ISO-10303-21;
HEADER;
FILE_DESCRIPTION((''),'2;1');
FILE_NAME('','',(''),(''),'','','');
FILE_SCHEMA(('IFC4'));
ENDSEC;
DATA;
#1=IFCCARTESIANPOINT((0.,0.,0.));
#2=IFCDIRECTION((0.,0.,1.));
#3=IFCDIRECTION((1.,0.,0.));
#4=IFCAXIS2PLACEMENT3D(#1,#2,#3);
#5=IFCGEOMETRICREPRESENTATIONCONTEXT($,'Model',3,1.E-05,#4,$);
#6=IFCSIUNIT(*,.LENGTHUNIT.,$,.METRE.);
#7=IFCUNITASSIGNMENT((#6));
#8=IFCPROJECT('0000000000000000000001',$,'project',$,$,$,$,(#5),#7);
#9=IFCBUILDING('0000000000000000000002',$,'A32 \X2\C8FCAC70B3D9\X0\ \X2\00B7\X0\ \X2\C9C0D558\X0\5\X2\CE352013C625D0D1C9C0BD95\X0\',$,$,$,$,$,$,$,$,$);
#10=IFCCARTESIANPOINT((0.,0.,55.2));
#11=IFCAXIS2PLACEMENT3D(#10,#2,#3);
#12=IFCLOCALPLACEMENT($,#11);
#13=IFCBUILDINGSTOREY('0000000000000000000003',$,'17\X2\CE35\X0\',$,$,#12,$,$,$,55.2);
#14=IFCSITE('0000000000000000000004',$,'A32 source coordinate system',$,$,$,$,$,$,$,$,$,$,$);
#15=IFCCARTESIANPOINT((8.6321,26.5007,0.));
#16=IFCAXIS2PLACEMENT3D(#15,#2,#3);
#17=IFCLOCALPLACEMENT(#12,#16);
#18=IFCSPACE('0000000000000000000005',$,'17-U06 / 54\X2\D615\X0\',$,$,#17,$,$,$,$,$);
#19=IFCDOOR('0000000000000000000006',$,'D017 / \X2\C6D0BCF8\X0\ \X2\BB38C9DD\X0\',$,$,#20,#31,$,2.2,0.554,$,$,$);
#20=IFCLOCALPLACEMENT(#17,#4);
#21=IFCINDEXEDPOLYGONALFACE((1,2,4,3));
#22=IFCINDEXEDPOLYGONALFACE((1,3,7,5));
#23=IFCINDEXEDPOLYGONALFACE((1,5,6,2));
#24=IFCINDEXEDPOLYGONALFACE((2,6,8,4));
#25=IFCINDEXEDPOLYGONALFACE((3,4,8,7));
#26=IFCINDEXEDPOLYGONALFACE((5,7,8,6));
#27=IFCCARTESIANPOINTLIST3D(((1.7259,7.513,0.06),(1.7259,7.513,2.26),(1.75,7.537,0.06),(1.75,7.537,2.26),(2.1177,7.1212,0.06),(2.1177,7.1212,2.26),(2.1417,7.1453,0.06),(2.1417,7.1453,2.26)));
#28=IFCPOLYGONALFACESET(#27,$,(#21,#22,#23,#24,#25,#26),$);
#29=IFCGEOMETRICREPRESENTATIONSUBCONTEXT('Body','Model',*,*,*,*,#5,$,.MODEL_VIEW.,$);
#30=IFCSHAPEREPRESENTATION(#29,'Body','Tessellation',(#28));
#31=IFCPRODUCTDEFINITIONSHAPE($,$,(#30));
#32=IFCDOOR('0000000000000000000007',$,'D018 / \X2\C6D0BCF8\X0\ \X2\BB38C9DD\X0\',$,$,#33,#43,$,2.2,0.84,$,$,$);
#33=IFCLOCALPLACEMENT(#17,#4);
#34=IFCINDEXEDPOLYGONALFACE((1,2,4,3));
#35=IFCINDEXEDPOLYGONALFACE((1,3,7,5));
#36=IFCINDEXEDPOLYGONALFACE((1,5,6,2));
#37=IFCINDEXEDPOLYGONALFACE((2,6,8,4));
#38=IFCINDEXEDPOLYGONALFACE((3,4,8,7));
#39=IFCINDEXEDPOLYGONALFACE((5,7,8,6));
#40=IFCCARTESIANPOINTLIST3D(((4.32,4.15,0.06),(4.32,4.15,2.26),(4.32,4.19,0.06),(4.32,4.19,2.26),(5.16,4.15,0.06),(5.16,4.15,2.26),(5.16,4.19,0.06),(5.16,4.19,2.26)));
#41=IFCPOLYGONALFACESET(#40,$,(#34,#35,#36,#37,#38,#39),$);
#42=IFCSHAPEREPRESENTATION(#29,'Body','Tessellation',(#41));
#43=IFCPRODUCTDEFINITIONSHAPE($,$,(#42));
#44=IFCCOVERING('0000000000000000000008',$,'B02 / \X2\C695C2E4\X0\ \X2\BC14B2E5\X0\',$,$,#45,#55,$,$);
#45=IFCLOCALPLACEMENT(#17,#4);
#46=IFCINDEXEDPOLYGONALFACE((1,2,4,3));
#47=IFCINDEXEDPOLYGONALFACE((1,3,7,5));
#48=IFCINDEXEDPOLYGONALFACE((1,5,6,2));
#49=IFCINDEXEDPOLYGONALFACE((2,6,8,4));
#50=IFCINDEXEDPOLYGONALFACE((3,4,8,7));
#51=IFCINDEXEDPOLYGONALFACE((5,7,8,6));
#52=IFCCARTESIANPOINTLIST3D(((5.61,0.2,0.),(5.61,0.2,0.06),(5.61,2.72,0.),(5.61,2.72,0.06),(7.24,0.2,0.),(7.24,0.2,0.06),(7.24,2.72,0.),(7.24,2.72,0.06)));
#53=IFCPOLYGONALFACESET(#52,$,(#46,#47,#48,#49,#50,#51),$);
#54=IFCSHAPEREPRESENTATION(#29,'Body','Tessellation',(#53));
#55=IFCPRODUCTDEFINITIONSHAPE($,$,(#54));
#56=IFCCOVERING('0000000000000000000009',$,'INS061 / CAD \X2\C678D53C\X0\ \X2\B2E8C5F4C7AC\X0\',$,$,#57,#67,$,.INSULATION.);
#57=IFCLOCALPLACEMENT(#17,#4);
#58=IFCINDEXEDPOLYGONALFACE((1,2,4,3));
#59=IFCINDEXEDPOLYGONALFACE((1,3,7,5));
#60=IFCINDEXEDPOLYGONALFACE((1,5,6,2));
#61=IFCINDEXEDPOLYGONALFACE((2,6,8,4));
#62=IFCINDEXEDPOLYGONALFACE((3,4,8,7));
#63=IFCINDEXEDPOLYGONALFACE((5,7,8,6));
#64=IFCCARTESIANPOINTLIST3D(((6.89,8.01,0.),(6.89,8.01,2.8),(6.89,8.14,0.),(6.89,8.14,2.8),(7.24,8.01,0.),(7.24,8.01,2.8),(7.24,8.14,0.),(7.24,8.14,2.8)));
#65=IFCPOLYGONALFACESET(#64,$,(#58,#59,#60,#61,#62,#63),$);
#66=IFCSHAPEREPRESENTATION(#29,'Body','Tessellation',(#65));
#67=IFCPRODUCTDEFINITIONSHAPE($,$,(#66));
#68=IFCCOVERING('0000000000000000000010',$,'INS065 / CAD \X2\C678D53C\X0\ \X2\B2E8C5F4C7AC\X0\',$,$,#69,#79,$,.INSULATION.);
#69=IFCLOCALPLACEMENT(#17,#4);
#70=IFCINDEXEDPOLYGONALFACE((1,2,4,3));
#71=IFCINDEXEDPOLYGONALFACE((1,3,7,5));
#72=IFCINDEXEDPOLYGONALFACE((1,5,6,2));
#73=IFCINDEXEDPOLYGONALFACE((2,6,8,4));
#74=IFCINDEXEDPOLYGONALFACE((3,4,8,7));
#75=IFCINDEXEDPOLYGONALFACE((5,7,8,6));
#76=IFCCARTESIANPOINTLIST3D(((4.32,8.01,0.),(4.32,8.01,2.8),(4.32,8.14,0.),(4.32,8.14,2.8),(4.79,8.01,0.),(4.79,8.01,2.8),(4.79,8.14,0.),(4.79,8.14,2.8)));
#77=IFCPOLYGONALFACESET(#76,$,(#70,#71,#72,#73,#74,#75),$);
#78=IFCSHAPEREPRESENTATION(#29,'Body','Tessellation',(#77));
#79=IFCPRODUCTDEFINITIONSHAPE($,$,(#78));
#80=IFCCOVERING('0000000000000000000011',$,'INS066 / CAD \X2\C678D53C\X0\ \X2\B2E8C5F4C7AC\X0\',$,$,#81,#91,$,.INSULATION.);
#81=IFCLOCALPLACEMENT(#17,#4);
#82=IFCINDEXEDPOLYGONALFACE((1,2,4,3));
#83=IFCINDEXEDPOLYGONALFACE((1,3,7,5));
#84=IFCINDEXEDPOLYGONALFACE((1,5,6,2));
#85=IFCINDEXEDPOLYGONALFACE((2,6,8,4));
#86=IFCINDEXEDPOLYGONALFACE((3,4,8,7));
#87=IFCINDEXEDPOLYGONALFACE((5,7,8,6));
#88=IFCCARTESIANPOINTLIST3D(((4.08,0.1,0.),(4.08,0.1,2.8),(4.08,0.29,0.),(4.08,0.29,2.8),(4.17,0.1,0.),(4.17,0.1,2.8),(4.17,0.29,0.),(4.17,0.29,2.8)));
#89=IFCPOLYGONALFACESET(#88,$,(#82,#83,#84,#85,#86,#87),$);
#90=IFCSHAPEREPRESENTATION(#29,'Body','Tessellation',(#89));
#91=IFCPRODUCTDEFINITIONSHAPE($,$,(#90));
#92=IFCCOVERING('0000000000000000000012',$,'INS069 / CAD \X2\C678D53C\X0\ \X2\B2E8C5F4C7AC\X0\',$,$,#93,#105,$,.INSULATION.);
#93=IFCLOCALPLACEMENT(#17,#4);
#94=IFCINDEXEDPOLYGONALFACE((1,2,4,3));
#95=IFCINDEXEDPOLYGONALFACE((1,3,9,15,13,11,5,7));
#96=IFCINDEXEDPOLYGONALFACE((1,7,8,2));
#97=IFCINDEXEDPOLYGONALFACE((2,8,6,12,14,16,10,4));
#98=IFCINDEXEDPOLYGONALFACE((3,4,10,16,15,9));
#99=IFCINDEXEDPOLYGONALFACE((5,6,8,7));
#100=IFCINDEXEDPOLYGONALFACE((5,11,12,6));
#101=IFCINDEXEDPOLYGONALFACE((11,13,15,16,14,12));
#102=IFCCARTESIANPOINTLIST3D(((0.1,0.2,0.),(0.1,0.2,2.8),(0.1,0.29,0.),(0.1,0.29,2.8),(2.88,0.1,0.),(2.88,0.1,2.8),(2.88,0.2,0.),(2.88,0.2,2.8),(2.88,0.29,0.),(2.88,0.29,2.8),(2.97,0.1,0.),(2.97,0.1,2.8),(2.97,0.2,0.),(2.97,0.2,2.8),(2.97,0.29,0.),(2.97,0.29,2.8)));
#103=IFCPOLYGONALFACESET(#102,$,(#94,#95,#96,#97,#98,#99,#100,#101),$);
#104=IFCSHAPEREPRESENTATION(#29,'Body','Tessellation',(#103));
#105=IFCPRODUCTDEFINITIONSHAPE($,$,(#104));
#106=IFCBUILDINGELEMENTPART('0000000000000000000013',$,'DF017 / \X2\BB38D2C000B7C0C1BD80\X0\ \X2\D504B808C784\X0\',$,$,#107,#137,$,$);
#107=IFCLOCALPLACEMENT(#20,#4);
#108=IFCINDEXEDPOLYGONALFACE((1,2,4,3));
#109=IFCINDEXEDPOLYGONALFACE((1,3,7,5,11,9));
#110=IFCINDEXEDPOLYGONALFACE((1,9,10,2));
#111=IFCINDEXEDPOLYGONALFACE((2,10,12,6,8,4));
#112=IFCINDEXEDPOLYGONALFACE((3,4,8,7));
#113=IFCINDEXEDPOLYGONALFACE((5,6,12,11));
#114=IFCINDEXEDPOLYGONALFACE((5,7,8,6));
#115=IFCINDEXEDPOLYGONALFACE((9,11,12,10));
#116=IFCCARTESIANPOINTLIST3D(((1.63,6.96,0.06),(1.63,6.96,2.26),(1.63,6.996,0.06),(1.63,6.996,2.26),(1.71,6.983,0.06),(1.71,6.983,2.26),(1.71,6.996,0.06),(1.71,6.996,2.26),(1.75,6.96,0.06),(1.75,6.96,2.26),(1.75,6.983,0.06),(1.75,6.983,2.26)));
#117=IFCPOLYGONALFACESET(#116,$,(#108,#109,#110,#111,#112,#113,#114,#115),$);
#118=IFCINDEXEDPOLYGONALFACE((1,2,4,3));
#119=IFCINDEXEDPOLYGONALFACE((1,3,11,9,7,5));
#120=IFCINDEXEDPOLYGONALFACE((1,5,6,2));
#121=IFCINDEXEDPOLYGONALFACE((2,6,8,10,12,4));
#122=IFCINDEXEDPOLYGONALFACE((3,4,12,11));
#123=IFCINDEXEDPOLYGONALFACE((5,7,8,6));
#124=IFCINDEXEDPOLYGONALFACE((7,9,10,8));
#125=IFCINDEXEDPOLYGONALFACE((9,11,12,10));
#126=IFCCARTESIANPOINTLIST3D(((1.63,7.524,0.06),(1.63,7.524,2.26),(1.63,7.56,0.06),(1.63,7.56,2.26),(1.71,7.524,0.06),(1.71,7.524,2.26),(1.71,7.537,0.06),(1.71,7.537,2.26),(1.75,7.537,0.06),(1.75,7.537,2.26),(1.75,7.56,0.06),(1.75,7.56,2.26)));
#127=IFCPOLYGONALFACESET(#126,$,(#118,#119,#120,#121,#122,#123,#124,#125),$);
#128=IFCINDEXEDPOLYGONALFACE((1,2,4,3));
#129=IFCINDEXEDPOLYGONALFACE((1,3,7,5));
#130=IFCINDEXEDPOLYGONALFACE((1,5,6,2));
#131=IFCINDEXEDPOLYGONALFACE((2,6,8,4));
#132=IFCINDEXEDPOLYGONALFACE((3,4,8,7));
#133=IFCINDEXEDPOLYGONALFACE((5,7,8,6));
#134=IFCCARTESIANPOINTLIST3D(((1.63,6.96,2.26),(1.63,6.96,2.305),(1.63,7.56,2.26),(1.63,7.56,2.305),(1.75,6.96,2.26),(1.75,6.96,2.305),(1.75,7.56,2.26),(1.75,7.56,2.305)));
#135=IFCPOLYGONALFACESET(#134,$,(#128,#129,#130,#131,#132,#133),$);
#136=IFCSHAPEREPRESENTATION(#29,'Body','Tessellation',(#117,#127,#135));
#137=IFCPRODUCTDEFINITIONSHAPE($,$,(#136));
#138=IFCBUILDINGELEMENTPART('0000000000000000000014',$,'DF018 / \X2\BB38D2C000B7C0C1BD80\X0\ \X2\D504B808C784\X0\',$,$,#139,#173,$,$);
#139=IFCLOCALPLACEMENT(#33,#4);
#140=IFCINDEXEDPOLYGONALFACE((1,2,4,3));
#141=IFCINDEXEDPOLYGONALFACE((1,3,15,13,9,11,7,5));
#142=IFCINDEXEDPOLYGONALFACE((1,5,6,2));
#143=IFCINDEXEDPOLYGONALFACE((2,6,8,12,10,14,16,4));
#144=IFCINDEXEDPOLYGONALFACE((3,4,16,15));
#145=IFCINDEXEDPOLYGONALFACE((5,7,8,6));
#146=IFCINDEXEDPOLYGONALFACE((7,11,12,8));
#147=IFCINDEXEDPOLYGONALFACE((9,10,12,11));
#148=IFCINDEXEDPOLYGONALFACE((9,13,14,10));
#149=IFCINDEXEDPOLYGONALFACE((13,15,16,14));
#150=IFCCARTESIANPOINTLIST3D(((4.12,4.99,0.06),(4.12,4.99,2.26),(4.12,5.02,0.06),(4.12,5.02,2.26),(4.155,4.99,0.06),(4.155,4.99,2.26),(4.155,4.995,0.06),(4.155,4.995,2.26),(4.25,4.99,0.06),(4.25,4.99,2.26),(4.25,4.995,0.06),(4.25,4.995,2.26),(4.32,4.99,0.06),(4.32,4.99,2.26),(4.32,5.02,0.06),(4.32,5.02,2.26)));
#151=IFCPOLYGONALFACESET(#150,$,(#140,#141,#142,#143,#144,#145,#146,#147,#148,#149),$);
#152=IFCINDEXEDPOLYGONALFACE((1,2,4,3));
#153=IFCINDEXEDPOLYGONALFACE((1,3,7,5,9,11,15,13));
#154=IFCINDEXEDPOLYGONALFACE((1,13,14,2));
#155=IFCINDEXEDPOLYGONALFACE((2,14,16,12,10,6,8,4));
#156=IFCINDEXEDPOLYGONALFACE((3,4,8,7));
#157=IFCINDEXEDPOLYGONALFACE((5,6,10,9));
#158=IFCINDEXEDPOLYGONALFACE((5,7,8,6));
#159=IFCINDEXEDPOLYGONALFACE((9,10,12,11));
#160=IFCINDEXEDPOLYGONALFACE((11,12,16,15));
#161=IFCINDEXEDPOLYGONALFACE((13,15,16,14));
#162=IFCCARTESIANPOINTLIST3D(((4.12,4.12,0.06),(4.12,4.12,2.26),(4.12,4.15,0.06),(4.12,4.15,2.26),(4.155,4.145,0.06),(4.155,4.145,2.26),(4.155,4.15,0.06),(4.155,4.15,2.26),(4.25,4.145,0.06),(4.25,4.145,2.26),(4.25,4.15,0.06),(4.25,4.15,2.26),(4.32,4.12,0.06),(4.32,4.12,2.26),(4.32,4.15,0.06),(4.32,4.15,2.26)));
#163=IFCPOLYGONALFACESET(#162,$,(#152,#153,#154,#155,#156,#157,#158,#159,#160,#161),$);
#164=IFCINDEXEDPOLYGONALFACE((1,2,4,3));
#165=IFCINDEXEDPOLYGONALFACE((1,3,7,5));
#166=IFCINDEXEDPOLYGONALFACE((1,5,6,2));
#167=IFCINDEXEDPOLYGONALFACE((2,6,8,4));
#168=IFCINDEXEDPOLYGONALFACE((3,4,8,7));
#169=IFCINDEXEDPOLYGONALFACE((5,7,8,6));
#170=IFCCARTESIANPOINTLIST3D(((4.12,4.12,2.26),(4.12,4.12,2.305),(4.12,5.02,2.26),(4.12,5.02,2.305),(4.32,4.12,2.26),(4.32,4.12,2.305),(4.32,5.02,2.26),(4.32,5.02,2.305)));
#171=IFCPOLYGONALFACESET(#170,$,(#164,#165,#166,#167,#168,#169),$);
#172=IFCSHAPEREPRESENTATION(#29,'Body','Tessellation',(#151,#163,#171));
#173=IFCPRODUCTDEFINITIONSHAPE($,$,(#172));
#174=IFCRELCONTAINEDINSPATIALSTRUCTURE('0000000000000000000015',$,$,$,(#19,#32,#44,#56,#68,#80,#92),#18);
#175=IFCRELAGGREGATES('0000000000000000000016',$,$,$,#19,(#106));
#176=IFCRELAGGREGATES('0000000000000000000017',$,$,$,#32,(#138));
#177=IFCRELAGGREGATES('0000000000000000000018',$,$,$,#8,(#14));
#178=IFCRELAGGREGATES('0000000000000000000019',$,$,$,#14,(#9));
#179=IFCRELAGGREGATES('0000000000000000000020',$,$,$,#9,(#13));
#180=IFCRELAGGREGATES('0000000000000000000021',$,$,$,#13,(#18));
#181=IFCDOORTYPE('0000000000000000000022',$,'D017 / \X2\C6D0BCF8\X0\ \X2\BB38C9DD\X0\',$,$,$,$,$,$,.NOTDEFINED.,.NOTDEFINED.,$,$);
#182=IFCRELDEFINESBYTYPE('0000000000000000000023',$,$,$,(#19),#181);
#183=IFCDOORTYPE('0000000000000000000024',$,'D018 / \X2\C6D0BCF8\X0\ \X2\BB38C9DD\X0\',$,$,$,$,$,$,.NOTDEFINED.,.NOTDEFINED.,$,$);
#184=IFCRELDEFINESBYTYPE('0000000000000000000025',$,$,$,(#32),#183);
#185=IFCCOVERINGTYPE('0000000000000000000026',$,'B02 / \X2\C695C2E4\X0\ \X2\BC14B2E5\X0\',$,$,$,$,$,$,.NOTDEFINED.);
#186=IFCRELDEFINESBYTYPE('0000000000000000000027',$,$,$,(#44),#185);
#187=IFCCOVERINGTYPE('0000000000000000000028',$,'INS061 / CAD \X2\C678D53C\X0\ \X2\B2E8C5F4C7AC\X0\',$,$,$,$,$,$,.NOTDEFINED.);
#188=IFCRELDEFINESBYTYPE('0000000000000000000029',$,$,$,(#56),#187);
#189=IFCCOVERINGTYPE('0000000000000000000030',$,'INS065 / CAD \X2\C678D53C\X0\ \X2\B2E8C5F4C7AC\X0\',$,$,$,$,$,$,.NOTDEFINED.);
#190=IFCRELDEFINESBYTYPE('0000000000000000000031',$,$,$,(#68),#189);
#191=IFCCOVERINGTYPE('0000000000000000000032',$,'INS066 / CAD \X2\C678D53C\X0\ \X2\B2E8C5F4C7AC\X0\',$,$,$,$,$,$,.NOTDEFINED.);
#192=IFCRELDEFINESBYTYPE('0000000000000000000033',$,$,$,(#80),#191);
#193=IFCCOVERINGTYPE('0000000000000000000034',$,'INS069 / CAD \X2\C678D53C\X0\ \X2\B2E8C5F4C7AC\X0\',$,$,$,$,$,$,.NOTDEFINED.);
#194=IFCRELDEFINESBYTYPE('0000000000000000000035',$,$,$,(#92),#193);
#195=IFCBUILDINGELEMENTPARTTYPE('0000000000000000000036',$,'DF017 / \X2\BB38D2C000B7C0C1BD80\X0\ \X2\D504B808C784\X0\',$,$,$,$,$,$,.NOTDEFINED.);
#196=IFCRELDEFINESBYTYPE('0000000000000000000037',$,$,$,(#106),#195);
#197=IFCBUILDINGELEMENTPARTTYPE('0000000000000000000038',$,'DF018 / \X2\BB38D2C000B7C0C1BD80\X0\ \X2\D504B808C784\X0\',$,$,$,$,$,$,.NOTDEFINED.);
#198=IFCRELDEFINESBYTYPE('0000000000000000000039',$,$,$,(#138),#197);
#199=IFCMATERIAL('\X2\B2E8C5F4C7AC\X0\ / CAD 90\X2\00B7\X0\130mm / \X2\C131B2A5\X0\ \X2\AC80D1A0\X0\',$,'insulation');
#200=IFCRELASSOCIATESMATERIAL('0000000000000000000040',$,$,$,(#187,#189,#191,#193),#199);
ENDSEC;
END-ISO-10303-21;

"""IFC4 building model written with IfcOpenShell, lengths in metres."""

from ifc_helpers import new_model, si_unit, frame, origin, origin_with_axes, place, context, subcontext, project, spatial, polyline, outline, extrude, source, transform, mapped, material, type_object, type_shapes, element, aggregate, save


model = new_model("IFC4")

# Units and contexts
model_context = context("Model", 3, precision=1e-05, world=origin_with_axes())
body_context = subcontext(model_context, "Body", "Model", "MODEL_VIEW")
ifc_project = project(units=[si_unit("LENGTHUNIT", "METRE")], contexts=[model_context])

# Site, building, storey, space
storey_placement = place(None, frame((0.0, 0.0, 55.2), z_axis=(0.0, 0.0, 1.0), x_axis=(1.0, 0.0, 0.0)))
space_1_placement = place(storey_placement, frame((8.6321, 26.5007, 0.0), z_axis=(0.0, 0.0, 1.0), x_axis=(1.0, 0.0, 0.0)))
site = spatial("IfcSite", under=ifc_project, Name="A32 source coordinate system")
building = spatial("IfcBuilding", under=site, Name="A32 주거동 · 지하5층–옥탑지붕")
storey = spatial("IfcBuildingStorey", under=building, at=storey_placement, Name="17층", Elevation=55.2)
space_1 = spatial("IfcSpace", under=storey, at=space_1_placement, Name="17-U06 / 54형")

# Doors
door_type_1 = type_object("IfcDoorType", Name="D017 / 원본 문짝", OperationType="NOTDEFINED", PredefinedType="NOTDEFINED")
shared_shape_1 = source(origin(), body_context, "Body", "SweptSolid", [
    extrude(outline(polyline([(1.75, 7.537), (2.1417, 7.1453), (2.1177, 7.1212), (1.7259, 7.513), (1.75, 7.537)])), frame((0.0, 0.0, 0.06)), (0.0, 0.0, 1.0), 2.2),
])
type_shapes(door_type_1, [shared_shape_1])
door_1_placement = place(space_1_placement, origin_with_axes())
door_1 = element("IfcDoor", 1, at=door_1_placement, inside=space_1, type_object=door_type_1, Name="D017 / 원본 문짝", OverallHeight=2.2, OverallWidth=0.554, context=body_context, shape_type="MappedRepresentation", body=[
    mapped(shared_shape_1, transform((0.0, 0.0, 0.0), scale=1.0)),
])
door_type_2 = type_object("IfcDoorType", Name="D018 / 원본 문짝", OperationType="NOTDEFINED", PredefinedType="NOTDEFINED")
shared_shape_2 = source(origin(), body_context, "Body", "SweptSolid", [
    extrude(outline(polyline([(5.16, 4.19), (5.16, 4.15), (4.32, 4.15), (4.32, 4.19), (5.16, 4.19)])), frame((0.0, 0.0, 0.06)), (0.0, 0.0, 1.0), 2.2),
])
type_shapes(door_type_2, [shared_shape_2])
door_2_placement = place(space_1_placement, origin_with_axes())
door_2 = element("IfcDoor", 2, at=door_2_placement, inside=space_1, type_object=door_type_2, Name="D018 / 원본 문짝", OverallHeight=2.2, OverallWidth=0.84, context=body_context, shape_type="MappedRepresentation", body=[
    mapped(shared_shape_2, transform((0.0, 0.0, 0.0), scale=1.0)),
])

# Coverings
covering_type_1 = type_object("IfcCoveringType", Name="B02 / 욕실 바닥", PredefinedType="NOTDEFINED")
shared_shape_3 = source(origin(), body_context, "Body", "SweptSolid", [
    extrude(outline(polyline([(5.61, 2.72), (7.24, 2.72), (7.24, 0.2), (5.61, 0.2), (5.61, 2.72)])), origin(), (0.0, 0.0, 1.0), 0.06),
])
type_shapes(covering_type_1, [shared_shape_3])
covering_1_placement = place(space_1_placement, origin_with_axes())
element("IfcCovering", 3, at=covering_1_placement, inside=space_1, type_object=covering_type_1, Name="B02 / 욕실 바닥", context=body_context, shape_type="MappedRepresentation", body=[
    mapped(shared_shape_3, transform((0.0, 0.0, 0.0), scale=1.0)),
])
ifc_material = material(Name="단열재 / CAD 90·130mm / 성능 검토", Category="insulation")
covering_type_2 = type_object("IfcCoveringType", Name="INS061 / CAD 외피 단열재", PredefinedType="NOTDEFINED", material=ifc_material)
shared_shape_4 = source(origin(), body_context, "Body", "SweptSolid", [
    extrude(outline(polyline([(6.89, 8.01), (6.89, 8.14), (7.24, 8.14), (7.24, 8.01), (6.89, 8.01)])), origin(), (0.0, 0.0, 1.0), 2.8),
])
type_shapes(covering_type_2, [shared_shape_4])
covering_2_placement = place(space_1_placement, origin_with_axes())
element("IfcCovering", 4, at=covering_2_placement, inside=space_1, type_object=covering_type_2, Name="INS061 / CAD 외피 단열재", PredefinedType="INSULATION", context=body_context, shape_type="MappedRepresentation", body=[
    mapped(shared_shape_4, transform((0.0, 0.0, 0.0), scale=1.0)),
])
covering_type_3 = type_object("IfcCoveringType", Name="INS065 / CAD 외피 단열재", PredefinedType="NOTDEFINED", material=ifc_material)
shared_shape_5 = source(origin(), body_context, "Body", "SweptSolid", [
    extrude(outline(polyline([(4.32, 8.01), (4.32, 8.14), (4.79, 8.14), (4.79, 8.01), (4.32, 8.01)])), origin(), (0.0, 0.0, 1.0), 2.8),
])
type_shapes(covering_type_3, [shared_shape_5])
covering_3_placement = place(space_1_placement, origin_with_axes())
element("IfcCovering", 5, at=covering_3_placement, inside=space_1, type_object=covering_type_3, Name="INS065 / CAD 외피 단열재", PredefinedType="INSULATION", context=body_context, shape_type="MappedRepresentation", body=[
    mapped(shared_shape_5, transform((0.0, 0.0, 0.0), scale=1.0)),
])
covering_type_4 = type_object("IfcCoveringType", Name="INS066 / CAD 외피 단열재", PredefinedType="NOTDEFINED", material=ifc_material)
shared_shape_6 = source(origin(), body_context, "Body", "SweptSolid", [
    extrude(outline(polyline([(4.08, 0.29), (4.17, 0.29), (4.17, 0.1), (4.08, 0.1), (4.08, 0.29)])), origin(), (0.0, 0.0, 1.0), 2.8),
])
type_shapes(covering_type_4, [shared_shape_6])
covering_4_placement = place(space_1_placement, origin_with_axes())
element("IfcCovering", 6, at=covering_4_placement, inside=space_1, type_object=covering_type_4, Name="INS066 / CAD 외피 단열재", PredefinedType="INSULATION", context=body_context, shape_type="MappedRepresentation", body=[
    mapped(shared_shape_6, transform((0.0, 0.0, 0.0), scale=1.0)),
])
covering_type_5 = type_object("IfcCoveringType", Name="INS069 / CAD 외피 단열재", PredefinedType="NOTDEFINED", material=ifc_material)
shared_shape_7 = source(origin(), body_context, "Body", "SweptSolid", [
    extrude(outline(polyline([(2.97, 0.1), (2.88, 0.1), (2.88, 0.2), (0.1, 0.2), (0.1, 0.29), (2.88, 0.29), (2.97, 0.29), (2.97, 0.2), (2.97, 0.1)])), origin(), (0.0, 0.0, 1.0), 2.8),
])
type_shapes(covering_type_5, [shared_shape_7])
covering_5_placement = place(space_1_placement, origin_with_axes())
element("IfcCovering", 7, at=covering_5_placement, inside=space_1, type_object=covering_type_5, Name="INS069 / CAD 외피 단열재", PredefinedType="INSULATION", context=body_context, shape_type="MappedRepresentation", body=[
    mapped(shared_shape_7, transform((0.0, 0.0, 0.0), scale=1.0)),
])

# Building element parts
building_element_part_type_1 = type_object("IfcBuildingElementPartType", Name="DF017 / 문틀·상부 프레임", PredefinedType="NOTDEFINED")
shared_shape_8 = source(origin(), body_context, "Body", "SweptSolid", [
    extrude(outline(polyline([(1.63, 6.996), (1.71, 6.996), (1.71, 6.983), (1.75, 6.983), (1.75, 6.96), (1.63, 6.96), (1.63, 6.996)])), frame((0.0, 0.0, 0.06)), (0.0, 0.0, 1.0), 2.2),
    extrude(outline(polyline([(1.75, 7.56), (1.75, 7.537), (1.71, 7.537), (1.71, 7.524), (1.63, 7.524), (1.63, 7.56), (1.75, 7.56)])), frame((0.0, 0.0, 0.06)), (0.0, 0.0, 1.0), 2.2),
    extrude(outline(polyline([(1.63, 6.96), (1.63, 7.56), (1.75, 7.56), (1.75, 6.96), (1.63, 6.96)])), frame((0.0, 0.0, 2.26)), (0.0, 0.0, 1.0), 0.045),
])
type_shapes(building_element_part_type_1, [shared_shape_8])
building_element_part_1_placement = place(door_1_placement, origin_with_axes())
building_element_part_1 = element("IfcBuildingElementPart", 8, at=building_element_part_1_placement, type_object=building_element_part_type_1, Name="DF017 / 문틀·상부 프레임", context=body_context, shape_type="MappedRepresentation", body=[
    mapped(shared_shape_8, transform((0.0, 0.0, 0.0), scale=1.0)),
])
aggregate(door_1, [building_element_part_1])
building_element_part_type_2 = type_object("IfcBuildingElementPartType", Name="DF018 / 문틀·상부 프레임", PredefinedType="NOTDEFINED")
shared_shape_9 = source(origin(), body_context, "Body", "SweptSolid", [
    extrude(outline(polyline([(4.32, 4.99), (4.25, 4.99), (4.25, 4.995), (4.155, 4.995), (4.155, 4.99), (4.12, 4.99), (4.12, 5.02), (4.32, 5.02), (4.32, 4.99)])), frame((0.0, 0.0, 0.06)), (0.0, 0.0, 1.0), 2.2),
    extrude(outline(polyline([(4.12, 4.12), (4.12, 4.15), (4.155, 4.15), (4.155, 4.145), (4.25, 4.145), (4.25, 4.15), (4.32, 4.15), (4.32, 4.12), (4.12, 4.12)])), frame((0.0, 0.0, 0.06)), (0.0, 0.0, 1.0), 2.2),
    extrude(outline(polyline([(4.12, 4.12), (4.12, 5.02), (4.32, 5.02), (4.32, 4.12), (4.12, 4.12)])), frame((0.0, 0.0, 2.26)), (0.0, 0.0, 1.0), 0.045),
])
type_shapes(building_element_part_type_2, [shared_shape_9])
building_element_part_2_placement = place(door_2_placement, origin_with_axes())
building_element_part_2 = element("IfcBuildingElementPart", 9, at=building_element_part_2_placement, type_object=building_element_part_type_2, Name="DF018 / 문틀·상부 프레임", context=body_context, shape_type="MappedRepresentation", body=[
    mapped(shared_shape_9, transform((0.0, 0.0, 0.0), scale=1.0)),
])
aggregate(door_2, [building_element_part_2])

save(model, "model.ifc")
